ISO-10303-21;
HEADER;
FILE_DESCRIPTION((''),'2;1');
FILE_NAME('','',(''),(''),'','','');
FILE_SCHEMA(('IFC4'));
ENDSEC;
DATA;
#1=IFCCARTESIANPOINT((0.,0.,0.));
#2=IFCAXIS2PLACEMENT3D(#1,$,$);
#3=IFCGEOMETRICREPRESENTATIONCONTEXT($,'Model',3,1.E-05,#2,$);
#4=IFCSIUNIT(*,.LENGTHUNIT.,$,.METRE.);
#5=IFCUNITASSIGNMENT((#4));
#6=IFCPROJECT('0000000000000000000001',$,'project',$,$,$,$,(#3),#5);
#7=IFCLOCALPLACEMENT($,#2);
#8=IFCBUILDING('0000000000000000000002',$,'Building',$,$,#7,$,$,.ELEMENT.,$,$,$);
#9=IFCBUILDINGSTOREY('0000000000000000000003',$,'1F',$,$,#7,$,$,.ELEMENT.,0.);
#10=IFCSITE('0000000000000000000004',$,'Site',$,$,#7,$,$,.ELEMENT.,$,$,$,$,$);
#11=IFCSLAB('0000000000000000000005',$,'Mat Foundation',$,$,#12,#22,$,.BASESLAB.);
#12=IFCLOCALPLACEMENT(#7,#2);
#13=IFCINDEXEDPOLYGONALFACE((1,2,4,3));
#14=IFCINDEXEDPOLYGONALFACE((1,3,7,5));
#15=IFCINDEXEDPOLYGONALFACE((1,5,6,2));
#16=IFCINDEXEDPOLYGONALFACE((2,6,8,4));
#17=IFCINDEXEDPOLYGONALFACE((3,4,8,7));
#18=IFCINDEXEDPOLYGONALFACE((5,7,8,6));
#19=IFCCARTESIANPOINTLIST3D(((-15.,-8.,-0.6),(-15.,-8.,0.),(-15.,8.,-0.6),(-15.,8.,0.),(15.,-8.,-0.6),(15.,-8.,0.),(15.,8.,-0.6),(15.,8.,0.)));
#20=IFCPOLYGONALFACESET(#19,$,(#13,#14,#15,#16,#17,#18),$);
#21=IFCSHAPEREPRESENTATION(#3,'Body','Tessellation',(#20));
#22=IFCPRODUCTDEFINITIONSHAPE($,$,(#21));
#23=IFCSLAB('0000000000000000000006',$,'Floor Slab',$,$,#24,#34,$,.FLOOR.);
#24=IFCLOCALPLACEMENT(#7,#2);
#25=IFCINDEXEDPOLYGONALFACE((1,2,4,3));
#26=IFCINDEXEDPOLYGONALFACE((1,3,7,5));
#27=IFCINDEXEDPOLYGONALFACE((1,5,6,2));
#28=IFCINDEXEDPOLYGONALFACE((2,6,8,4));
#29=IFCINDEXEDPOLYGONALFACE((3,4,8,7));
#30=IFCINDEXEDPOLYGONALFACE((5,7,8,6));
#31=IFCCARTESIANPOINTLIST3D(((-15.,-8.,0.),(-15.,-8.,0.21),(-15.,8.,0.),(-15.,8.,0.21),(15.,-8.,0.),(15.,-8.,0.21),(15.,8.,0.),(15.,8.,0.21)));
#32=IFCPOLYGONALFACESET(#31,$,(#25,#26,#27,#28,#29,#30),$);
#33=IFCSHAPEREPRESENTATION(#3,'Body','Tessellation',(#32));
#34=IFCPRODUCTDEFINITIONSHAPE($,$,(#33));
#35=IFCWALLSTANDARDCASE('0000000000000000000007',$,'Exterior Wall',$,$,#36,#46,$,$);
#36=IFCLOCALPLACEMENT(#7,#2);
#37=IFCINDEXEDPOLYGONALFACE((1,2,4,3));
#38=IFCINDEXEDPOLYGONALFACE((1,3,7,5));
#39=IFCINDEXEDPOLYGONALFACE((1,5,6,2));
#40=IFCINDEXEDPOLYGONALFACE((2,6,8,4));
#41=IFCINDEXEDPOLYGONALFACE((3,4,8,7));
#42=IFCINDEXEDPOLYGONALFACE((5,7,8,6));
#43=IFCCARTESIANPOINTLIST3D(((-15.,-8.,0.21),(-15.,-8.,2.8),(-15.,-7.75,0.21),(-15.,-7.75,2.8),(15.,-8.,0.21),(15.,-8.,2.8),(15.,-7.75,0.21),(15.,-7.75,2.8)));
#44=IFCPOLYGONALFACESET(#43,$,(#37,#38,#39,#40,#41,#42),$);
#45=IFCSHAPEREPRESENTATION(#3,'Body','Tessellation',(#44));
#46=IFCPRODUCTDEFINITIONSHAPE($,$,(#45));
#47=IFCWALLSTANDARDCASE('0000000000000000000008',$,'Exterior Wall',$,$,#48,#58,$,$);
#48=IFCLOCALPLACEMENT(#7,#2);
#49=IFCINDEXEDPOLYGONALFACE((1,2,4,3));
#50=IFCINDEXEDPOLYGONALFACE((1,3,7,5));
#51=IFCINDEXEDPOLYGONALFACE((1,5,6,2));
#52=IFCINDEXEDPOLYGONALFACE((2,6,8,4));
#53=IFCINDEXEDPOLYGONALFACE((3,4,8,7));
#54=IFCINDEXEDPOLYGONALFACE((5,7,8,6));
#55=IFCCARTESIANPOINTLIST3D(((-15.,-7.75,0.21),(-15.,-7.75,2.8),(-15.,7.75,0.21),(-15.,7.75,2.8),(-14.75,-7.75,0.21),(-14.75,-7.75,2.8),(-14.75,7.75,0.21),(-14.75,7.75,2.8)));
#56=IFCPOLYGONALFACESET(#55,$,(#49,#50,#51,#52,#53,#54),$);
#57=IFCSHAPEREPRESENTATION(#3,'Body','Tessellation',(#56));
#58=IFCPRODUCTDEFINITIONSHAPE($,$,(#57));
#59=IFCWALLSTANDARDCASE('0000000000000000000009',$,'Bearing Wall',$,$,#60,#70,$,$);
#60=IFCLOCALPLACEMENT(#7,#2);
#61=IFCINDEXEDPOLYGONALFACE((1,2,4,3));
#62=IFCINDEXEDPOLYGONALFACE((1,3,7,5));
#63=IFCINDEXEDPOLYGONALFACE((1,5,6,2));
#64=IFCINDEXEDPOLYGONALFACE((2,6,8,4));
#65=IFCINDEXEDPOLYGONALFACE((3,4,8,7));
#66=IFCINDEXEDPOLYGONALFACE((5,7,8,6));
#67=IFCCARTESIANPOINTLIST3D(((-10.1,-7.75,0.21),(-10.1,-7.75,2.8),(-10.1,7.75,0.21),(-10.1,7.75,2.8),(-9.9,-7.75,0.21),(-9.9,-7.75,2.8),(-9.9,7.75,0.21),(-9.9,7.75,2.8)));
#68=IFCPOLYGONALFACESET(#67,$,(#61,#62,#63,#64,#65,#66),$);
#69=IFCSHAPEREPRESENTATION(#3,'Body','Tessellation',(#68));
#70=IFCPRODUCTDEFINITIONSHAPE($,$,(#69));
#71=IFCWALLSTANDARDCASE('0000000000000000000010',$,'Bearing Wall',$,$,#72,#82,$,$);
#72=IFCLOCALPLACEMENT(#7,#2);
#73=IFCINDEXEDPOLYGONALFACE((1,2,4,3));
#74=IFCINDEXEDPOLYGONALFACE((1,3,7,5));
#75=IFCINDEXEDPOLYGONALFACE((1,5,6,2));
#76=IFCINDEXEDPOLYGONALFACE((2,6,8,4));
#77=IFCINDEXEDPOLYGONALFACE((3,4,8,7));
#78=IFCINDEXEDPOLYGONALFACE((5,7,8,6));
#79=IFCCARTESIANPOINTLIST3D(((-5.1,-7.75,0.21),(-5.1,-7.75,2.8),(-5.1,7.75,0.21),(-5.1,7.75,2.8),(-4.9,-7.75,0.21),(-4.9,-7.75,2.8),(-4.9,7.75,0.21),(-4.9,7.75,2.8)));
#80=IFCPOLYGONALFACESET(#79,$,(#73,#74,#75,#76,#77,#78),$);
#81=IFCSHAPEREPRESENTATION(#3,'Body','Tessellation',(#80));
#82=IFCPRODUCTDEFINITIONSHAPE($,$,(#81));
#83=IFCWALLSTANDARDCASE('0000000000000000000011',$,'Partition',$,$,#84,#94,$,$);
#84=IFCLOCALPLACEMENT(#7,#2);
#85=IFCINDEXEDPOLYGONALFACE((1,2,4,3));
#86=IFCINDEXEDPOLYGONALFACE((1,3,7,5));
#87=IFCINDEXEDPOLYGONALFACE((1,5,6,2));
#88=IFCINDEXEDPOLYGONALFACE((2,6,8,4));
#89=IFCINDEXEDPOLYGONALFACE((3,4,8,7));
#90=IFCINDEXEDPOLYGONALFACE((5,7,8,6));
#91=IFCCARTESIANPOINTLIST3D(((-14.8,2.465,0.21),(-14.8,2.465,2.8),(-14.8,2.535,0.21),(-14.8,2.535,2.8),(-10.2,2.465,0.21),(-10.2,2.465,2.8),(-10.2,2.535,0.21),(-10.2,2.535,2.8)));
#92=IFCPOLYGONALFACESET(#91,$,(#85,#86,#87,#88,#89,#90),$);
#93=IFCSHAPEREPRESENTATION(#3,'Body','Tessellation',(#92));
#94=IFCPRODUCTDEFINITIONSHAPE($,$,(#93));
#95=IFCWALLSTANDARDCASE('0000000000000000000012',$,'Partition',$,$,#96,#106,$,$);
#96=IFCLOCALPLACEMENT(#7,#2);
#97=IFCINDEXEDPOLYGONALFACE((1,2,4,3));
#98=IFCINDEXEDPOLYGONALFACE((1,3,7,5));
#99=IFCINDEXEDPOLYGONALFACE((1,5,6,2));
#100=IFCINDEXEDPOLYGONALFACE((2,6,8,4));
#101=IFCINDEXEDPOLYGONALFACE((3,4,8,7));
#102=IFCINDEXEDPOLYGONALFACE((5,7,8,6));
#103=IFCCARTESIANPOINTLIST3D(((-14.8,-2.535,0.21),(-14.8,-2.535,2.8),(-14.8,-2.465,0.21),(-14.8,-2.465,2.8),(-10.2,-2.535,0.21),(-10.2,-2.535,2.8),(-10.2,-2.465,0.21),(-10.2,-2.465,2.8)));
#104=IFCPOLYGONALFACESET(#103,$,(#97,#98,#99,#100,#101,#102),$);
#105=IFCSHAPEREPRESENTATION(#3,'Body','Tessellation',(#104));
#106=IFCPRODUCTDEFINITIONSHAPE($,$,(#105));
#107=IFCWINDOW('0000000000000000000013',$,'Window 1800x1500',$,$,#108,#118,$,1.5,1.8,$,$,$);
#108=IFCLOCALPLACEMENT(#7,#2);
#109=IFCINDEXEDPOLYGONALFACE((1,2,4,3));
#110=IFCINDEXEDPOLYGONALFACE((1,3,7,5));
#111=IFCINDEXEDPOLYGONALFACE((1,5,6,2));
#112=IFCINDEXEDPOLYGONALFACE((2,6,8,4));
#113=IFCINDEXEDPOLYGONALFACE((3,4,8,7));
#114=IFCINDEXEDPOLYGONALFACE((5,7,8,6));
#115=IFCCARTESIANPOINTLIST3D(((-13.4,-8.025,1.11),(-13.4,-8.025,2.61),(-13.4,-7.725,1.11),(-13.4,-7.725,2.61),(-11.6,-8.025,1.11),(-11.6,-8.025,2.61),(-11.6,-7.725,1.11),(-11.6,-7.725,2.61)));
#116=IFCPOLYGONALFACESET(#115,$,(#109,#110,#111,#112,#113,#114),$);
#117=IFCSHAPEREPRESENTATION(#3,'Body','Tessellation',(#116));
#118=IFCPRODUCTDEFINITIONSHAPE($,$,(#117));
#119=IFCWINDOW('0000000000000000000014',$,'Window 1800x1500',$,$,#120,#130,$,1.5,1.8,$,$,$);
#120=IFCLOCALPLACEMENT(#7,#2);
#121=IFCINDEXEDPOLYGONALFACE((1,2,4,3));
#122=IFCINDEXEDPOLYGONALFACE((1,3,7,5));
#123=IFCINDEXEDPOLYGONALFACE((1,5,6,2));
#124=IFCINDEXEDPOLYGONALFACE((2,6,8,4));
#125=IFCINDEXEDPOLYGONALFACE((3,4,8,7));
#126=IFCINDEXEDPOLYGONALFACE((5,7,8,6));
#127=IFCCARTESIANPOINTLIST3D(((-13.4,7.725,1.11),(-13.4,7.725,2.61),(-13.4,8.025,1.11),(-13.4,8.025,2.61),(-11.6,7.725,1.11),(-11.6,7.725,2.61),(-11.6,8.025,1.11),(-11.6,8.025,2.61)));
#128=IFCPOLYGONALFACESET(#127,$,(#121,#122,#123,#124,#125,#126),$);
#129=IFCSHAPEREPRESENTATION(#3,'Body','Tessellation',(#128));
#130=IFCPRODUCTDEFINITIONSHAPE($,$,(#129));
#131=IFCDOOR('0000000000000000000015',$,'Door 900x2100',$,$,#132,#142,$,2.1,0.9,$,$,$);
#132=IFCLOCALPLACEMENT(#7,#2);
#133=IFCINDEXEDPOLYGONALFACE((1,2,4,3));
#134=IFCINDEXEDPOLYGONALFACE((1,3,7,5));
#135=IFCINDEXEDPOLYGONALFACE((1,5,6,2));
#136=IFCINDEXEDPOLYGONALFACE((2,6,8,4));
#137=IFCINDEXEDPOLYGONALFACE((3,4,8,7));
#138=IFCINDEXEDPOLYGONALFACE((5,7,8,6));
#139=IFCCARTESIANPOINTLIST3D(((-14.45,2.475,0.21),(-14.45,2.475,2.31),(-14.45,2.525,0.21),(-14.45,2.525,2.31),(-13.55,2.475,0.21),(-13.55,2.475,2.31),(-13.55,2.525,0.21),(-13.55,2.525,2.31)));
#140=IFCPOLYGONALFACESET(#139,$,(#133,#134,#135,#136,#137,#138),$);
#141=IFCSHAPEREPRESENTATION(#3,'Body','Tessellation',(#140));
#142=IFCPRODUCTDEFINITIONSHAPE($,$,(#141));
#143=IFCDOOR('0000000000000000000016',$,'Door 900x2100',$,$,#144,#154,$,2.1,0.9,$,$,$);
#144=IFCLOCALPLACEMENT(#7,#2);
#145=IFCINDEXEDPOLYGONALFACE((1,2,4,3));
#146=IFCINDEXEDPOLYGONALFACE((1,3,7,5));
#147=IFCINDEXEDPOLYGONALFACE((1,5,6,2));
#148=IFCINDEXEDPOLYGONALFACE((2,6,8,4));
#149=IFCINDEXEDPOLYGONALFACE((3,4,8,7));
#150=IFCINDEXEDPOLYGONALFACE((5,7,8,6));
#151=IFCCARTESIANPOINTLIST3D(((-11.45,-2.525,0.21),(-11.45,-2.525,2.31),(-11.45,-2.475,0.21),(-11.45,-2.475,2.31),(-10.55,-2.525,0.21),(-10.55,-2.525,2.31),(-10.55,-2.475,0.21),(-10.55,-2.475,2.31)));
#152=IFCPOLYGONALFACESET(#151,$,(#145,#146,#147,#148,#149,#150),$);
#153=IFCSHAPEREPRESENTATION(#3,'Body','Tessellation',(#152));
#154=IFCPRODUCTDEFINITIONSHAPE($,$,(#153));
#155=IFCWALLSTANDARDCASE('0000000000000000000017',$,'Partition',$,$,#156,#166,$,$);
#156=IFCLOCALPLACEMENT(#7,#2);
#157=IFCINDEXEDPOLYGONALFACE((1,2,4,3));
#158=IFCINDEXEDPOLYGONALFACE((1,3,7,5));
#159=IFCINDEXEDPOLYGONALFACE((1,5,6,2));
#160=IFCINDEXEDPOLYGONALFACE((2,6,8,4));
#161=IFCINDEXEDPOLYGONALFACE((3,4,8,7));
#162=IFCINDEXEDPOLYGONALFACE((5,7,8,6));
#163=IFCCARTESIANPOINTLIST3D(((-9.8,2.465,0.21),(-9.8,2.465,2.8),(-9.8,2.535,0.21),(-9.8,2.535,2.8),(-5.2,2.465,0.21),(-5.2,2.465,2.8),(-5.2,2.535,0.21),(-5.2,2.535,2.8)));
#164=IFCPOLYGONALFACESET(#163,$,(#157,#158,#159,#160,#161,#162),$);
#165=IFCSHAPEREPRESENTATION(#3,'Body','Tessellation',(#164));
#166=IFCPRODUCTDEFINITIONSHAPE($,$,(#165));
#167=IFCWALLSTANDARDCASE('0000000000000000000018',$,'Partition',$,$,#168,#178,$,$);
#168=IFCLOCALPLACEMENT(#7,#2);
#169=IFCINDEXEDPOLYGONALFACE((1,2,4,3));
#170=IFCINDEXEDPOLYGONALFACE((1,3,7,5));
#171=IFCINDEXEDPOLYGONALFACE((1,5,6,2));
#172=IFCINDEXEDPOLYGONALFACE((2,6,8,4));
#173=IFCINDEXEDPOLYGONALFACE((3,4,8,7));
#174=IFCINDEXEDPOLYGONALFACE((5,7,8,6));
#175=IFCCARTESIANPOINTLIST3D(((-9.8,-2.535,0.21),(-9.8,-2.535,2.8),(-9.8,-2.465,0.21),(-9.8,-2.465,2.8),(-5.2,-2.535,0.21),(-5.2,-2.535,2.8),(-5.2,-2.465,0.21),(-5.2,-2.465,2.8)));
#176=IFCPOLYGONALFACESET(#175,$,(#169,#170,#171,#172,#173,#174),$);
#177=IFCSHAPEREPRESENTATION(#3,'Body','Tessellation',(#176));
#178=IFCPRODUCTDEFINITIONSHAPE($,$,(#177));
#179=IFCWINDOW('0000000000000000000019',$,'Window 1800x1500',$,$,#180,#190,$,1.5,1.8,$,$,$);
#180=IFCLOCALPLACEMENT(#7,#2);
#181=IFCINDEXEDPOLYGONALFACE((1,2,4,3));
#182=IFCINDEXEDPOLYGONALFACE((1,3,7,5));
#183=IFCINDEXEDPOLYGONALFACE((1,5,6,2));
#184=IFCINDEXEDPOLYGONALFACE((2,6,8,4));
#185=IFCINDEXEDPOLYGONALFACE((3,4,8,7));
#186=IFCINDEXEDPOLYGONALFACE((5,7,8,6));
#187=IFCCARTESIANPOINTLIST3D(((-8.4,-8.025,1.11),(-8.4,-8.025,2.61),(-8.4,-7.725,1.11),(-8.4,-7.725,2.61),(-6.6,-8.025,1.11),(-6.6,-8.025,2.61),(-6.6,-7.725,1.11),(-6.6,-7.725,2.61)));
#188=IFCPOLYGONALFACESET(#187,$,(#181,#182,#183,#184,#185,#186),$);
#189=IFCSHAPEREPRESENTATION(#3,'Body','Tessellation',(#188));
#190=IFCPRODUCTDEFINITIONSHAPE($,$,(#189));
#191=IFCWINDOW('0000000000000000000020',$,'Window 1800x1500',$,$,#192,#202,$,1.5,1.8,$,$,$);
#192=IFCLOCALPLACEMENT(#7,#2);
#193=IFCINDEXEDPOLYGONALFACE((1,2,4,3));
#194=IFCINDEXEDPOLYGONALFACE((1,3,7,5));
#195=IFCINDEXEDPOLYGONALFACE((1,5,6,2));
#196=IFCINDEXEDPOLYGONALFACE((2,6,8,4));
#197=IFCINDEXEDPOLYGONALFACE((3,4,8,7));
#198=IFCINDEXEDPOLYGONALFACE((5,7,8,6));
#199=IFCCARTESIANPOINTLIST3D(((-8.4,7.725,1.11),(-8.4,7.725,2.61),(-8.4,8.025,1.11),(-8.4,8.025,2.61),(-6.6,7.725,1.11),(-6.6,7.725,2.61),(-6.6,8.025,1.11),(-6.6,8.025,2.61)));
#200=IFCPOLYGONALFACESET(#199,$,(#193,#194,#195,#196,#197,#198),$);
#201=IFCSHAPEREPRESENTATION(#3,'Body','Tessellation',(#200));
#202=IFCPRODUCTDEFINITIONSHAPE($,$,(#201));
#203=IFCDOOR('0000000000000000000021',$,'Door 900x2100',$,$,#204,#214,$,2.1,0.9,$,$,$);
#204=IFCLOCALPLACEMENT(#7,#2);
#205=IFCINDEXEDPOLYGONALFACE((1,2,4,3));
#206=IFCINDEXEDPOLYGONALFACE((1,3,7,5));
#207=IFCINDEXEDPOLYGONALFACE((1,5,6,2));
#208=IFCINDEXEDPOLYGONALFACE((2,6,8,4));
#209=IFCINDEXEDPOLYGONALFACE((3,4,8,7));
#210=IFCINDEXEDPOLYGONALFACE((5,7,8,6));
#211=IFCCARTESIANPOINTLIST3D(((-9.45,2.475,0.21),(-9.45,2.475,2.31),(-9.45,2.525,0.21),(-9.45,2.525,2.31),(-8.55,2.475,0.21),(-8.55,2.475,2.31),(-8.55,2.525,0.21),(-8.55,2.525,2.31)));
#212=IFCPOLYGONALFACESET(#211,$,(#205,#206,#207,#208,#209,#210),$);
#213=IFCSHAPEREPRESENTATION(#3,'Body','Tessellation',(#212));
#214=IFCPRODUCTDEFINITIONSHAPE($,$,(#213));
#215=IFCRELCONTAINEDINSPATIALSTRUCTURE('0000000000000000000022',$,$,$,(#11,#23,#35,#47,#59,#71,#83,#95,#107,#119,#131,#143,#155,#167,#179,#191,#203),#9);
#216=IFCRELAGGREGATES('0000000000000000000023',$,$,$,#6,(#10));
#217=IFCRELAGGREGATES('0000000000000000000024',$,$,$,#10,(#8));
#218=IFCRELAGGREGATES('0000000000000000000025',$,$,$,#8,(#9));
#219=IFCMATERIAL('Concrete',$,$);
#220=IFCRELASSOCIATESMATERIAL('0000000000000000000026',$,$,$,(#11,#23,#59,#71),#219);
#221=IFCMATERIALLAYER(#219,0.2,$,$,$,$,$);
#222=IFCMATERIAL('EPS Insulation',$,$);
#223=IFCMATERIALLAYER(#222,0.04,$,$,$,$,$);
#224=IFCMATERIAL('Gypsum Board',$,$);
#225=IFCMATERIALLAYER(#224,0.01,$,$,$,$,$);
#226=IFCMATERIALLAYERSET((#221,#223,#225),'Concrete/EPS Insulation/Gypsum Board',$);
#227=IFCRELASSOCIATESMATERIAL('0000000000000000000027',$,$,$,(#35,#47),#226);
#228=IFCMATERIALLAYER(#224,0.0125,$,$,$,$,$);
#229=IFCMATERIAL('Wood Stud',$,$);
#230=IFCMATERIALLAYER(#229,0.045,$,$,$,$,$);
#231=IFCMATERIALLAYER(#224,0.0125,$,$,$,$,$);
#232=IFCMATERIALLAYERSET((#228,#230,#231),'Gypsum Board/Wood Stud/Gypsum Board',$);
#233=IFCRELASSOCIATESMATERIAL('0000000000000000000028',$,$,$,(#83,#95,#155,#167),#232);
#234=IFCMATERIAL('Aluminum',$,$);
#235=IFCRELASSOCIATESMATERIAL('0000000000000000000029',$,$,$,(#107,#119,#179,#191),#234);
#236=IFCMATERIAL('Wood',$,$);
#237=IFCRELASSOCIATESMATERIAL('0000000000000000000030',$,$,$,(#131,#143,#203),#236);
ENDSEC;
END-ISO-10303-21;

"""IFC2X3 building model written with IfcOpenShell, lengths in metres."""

from ifc_helpers import new_model, si_unit, frame, origin, origin_2d, place, context, project, spatial, rectangle, extrude, material, layer, layer_set, layer_usage, element, save


model = new_model("IFC2X3")

# Units and contexts
model_context = context("Model", 3, precision=1e-05, world=origin())
ifc_project = project(units=[si_unit("LENGTHUNIT", "METRE")], contexts=[model_context])

# Site, building, storey
placement = place(None, origin())
site = spatial("IfcSite", under=ifc_project, at=placement, Name="Site", CompositionType="ELEMENT")
building = spatial("IfcBuilding", under=site, at=placement, Name="Building", CompositionType="ELEMENT")
storey = spatial("IfcBuildingStorey", under=building, at=placement, Name="1F", CompositionType="ELEMENT", Elevation=0.0)

# Slabs
ifc_material_1 = material(Name="Concrete")
slab_1_placement = place(None, frame((0.0, 0.0, -0.6)))
element("IfcSlab", 1, at=slab_1_placement, inside=storey, material=ifc_material_1, Name="Mat Foundation", PredefinedType="BASESLAB", context=model_context, shape_type="SweptSolid", body=[
    extrude(rectangle(XDim=30.0, YDim=16.0, at=origin_2d()), origin(), (0.0, 0.0, 1.0), 0.6),
])
slab_2_placement = place(None, origin())
element("IfcSlab", 2, at=slab_2_placement, inside=storey, material=ifc_material_1, Name="Floor Slab", PredefinedType="FLOOR", context=model_context, shape_type="SweptSolid", body=[
    extrude(rectangle(XDim=30.0, YDim=16.0, at=origin_2d()), origin(), (0.0, 0.0, 1.0), 0.21),
])

# Walls
ifc_layer_1 = layer(ifc_material_1, 0.2)
ifc_material_2 = material(Name="EPS Insulation")
ifc_layer_2 = layer(ifc_material_2, 0.04)
ifc_material_3 = material(Name="Gypsum Board")
ifc_layer_3 = layer(ifc_material_3, 0.01)
ifc_layer_set_1 = layer_set([ifc_layer_1, ifc_layer_2, ifc_layer_3], Name="Concrete/EPS Insulation/Gypsum Board")
ifc_layer_usage_1 = layer_usage(ifc_layer_set_1, "AXIS2", "POSITIVE", 0.0)
wall_1_placement = place(None, frame((0.0, -7.875, 0.21)))
element("IfcWallStandardCase", 3, at=wall_1_placement, inside=storey, material=ifc_layer_usage_1, Name="Exterior Wall", context=model_context, shape_type="SweptSolid", body=[
    extrude(rectangle(XDim=30.0, YDim=0.25, at=origin_2d()), origin(), (0.0, 0.0, 1.0), 2.59),
])
wall_2_placement = place(None, frame((-14.875, 0.0, 0.21)))
element("IfcWallStandardCase", 4, at=wall_2_placement, inside=storey, material=ifc_layer_usage_1, Name="Exterior Wall", context=model_context, shape_type="SweptSolid", body=[
    extrude(rectangle(XDim=0.25, YDim=15.5, at=origin_2d()), origin(), (0.0, 0.0, 1.0), 2.59),
])
for number, where, name in (
    (5, (-10.0, 0.0, 0.21), "Bearing Wall"),
    (6, (-5.0, 0.0, 0.21), "Bearing Wall"),
):
    element("IfcWallStandardCase", number, at=place(None, frame(where)), inside=storey, material=ifc_material_1, Name=name, context=model_context, shape_type="SweptSolid", body=[
        extrude(rectangle(XDim=0.2, YDim=15.5, at=origin_2d()), origin(), (0.0, 0.0, 1.0), 2.59),
    ])
ifc_layer_4 = layer(ifc_material_3, 0.0125)
ifc_material_4 = material(Name="Wood Stud")
ifc_layer_5 = layer(ifc_material_4, 0.045)
ifc_layer_6 = layer(ifc_material_3, 0.0125)
ifc_layer_set_2 = layer_set([ifc_layer_4, ifc_layer_5, ifc_layer_6], Name="Gypsum Board/Wood Stud/Gypsum Board")
ifc_layer_usage_2 = layer_usage(ifc_layer_set_2, "AXIS2", "POSITIVE", 0.0)
for number, where, name in (
    (7, (-12.5, 2.5, 0.21), "Partition"),
    (8, (-12.5, -2.5, 0.21), "Partition"),
):
    element("IfcWallStandardCase", number, at=place(None, frame(where)), inside=storey, material=ifc_layer_usage_2, Name=name, context=model_context, shape_type="SweptSolid", body=[
        extrude(rectangle(XDim=4.6, YDim=0.07, at=origin_2d()), origin(), (0.0, 0.0, 1.0), 2.59),
    ])

# Windows
ifc_material_5 = material(Name="Aluminum")
for number, where, name in (
    (9, (-12.5, -7.875, 1.11), "Window 1800x1500"),
    (10, (-12.5, 7.875, 1.11), "Window 1800x1500"),
):
    element("IfcWindow", number, at=place(None, frame(where)), inside=storey, material=ifc_material_5, Name=name, OverallHeight=1.5, OverallWidth=1.8, context=model_context, shape_type="SweptSolid", body=[
        extrude(rectangle(XDim=1.8, YDim=0.3, at=origin_2d()), origin(), (0.0, 0.0, 1.0), 1.5),
    ])

# Doors
ifc_material_6 = material(Name="Wood")
for number, where, name in (
    (11, (-14.0, 2.5, 0.21), "Door 900x2100"),
    (12, (-11.0, -2.5, 0.21), "Door 900x2100"),
):
    element("IfcDoor", number, at=place(None, frame(where)), inside=storey, material=ifc_material_6, Name=name, OverallHeight=2.1, OverallWidth=0.9, context=model_context, shape_type="SweptSolid", body=[
        extrude(rectangle(XDim=0.9, YDim=0.05, at=origin_2d()), origin(), (0.0, 0.0, 1.0), 2.1),
    ])

# Walls
for number, where, name in (
    (13, (-7.5, 2.5, 0.21), "Partition"),
    (14, (-7.5, -2.5, 0.21), "Partition"),
):
    element("IfcWallStandardCase", number, at=place(None, frame(where)), inside=storey, material=ifc_layer_usage_2, Name=name, context=model_context, shape_type="SweptSolid", body=[
        extrude(rectangle(XDim=4.6, YDim=0.07, at=origin_2d()), origin(), (0.0, 0.0, 1.0), 2.59),
    ])

# Windows
for number, where, name in (
    (15, (-7.5, -7.875, 1.11), "Window 1800x1500"),
    (16, (-7.5, 7.875, 1.11), "Window 1800x1500"),
):
    element("IfcWindow", number, at=place(None, frame(where)), inside=storey, material=ifc_material_5, Name=name, OverallHeight=1.5, OverallWidth=1.8, context=model_context, shape_type="SweptSolid", body=[
        extrude(rectangle(XDim=1.8, YDim=0.3, at=origin_2d()), origin(), (0.0, 0.0, 1.0), 1.5),
    ])

# Door
for number, where, name in (
    (17, (-9.0, 2.5, 0.21), "Door 900x2100"),
):
    element("IfcDoor", number, at=place(None, frame(where)), inside=storey, material=ifc_material_6, Name=name, OverallHeight=2.1, OverallWidth=0.9, context=model_context, shape_type="SweptSolid", body=[
        extrude(rectangle(XDim=0.9, YDim=0.05, at=origin_2d()), origin(), (0.0, 0.0, 1.0), 2.1),
    ])

save(model, "model.ifc")
